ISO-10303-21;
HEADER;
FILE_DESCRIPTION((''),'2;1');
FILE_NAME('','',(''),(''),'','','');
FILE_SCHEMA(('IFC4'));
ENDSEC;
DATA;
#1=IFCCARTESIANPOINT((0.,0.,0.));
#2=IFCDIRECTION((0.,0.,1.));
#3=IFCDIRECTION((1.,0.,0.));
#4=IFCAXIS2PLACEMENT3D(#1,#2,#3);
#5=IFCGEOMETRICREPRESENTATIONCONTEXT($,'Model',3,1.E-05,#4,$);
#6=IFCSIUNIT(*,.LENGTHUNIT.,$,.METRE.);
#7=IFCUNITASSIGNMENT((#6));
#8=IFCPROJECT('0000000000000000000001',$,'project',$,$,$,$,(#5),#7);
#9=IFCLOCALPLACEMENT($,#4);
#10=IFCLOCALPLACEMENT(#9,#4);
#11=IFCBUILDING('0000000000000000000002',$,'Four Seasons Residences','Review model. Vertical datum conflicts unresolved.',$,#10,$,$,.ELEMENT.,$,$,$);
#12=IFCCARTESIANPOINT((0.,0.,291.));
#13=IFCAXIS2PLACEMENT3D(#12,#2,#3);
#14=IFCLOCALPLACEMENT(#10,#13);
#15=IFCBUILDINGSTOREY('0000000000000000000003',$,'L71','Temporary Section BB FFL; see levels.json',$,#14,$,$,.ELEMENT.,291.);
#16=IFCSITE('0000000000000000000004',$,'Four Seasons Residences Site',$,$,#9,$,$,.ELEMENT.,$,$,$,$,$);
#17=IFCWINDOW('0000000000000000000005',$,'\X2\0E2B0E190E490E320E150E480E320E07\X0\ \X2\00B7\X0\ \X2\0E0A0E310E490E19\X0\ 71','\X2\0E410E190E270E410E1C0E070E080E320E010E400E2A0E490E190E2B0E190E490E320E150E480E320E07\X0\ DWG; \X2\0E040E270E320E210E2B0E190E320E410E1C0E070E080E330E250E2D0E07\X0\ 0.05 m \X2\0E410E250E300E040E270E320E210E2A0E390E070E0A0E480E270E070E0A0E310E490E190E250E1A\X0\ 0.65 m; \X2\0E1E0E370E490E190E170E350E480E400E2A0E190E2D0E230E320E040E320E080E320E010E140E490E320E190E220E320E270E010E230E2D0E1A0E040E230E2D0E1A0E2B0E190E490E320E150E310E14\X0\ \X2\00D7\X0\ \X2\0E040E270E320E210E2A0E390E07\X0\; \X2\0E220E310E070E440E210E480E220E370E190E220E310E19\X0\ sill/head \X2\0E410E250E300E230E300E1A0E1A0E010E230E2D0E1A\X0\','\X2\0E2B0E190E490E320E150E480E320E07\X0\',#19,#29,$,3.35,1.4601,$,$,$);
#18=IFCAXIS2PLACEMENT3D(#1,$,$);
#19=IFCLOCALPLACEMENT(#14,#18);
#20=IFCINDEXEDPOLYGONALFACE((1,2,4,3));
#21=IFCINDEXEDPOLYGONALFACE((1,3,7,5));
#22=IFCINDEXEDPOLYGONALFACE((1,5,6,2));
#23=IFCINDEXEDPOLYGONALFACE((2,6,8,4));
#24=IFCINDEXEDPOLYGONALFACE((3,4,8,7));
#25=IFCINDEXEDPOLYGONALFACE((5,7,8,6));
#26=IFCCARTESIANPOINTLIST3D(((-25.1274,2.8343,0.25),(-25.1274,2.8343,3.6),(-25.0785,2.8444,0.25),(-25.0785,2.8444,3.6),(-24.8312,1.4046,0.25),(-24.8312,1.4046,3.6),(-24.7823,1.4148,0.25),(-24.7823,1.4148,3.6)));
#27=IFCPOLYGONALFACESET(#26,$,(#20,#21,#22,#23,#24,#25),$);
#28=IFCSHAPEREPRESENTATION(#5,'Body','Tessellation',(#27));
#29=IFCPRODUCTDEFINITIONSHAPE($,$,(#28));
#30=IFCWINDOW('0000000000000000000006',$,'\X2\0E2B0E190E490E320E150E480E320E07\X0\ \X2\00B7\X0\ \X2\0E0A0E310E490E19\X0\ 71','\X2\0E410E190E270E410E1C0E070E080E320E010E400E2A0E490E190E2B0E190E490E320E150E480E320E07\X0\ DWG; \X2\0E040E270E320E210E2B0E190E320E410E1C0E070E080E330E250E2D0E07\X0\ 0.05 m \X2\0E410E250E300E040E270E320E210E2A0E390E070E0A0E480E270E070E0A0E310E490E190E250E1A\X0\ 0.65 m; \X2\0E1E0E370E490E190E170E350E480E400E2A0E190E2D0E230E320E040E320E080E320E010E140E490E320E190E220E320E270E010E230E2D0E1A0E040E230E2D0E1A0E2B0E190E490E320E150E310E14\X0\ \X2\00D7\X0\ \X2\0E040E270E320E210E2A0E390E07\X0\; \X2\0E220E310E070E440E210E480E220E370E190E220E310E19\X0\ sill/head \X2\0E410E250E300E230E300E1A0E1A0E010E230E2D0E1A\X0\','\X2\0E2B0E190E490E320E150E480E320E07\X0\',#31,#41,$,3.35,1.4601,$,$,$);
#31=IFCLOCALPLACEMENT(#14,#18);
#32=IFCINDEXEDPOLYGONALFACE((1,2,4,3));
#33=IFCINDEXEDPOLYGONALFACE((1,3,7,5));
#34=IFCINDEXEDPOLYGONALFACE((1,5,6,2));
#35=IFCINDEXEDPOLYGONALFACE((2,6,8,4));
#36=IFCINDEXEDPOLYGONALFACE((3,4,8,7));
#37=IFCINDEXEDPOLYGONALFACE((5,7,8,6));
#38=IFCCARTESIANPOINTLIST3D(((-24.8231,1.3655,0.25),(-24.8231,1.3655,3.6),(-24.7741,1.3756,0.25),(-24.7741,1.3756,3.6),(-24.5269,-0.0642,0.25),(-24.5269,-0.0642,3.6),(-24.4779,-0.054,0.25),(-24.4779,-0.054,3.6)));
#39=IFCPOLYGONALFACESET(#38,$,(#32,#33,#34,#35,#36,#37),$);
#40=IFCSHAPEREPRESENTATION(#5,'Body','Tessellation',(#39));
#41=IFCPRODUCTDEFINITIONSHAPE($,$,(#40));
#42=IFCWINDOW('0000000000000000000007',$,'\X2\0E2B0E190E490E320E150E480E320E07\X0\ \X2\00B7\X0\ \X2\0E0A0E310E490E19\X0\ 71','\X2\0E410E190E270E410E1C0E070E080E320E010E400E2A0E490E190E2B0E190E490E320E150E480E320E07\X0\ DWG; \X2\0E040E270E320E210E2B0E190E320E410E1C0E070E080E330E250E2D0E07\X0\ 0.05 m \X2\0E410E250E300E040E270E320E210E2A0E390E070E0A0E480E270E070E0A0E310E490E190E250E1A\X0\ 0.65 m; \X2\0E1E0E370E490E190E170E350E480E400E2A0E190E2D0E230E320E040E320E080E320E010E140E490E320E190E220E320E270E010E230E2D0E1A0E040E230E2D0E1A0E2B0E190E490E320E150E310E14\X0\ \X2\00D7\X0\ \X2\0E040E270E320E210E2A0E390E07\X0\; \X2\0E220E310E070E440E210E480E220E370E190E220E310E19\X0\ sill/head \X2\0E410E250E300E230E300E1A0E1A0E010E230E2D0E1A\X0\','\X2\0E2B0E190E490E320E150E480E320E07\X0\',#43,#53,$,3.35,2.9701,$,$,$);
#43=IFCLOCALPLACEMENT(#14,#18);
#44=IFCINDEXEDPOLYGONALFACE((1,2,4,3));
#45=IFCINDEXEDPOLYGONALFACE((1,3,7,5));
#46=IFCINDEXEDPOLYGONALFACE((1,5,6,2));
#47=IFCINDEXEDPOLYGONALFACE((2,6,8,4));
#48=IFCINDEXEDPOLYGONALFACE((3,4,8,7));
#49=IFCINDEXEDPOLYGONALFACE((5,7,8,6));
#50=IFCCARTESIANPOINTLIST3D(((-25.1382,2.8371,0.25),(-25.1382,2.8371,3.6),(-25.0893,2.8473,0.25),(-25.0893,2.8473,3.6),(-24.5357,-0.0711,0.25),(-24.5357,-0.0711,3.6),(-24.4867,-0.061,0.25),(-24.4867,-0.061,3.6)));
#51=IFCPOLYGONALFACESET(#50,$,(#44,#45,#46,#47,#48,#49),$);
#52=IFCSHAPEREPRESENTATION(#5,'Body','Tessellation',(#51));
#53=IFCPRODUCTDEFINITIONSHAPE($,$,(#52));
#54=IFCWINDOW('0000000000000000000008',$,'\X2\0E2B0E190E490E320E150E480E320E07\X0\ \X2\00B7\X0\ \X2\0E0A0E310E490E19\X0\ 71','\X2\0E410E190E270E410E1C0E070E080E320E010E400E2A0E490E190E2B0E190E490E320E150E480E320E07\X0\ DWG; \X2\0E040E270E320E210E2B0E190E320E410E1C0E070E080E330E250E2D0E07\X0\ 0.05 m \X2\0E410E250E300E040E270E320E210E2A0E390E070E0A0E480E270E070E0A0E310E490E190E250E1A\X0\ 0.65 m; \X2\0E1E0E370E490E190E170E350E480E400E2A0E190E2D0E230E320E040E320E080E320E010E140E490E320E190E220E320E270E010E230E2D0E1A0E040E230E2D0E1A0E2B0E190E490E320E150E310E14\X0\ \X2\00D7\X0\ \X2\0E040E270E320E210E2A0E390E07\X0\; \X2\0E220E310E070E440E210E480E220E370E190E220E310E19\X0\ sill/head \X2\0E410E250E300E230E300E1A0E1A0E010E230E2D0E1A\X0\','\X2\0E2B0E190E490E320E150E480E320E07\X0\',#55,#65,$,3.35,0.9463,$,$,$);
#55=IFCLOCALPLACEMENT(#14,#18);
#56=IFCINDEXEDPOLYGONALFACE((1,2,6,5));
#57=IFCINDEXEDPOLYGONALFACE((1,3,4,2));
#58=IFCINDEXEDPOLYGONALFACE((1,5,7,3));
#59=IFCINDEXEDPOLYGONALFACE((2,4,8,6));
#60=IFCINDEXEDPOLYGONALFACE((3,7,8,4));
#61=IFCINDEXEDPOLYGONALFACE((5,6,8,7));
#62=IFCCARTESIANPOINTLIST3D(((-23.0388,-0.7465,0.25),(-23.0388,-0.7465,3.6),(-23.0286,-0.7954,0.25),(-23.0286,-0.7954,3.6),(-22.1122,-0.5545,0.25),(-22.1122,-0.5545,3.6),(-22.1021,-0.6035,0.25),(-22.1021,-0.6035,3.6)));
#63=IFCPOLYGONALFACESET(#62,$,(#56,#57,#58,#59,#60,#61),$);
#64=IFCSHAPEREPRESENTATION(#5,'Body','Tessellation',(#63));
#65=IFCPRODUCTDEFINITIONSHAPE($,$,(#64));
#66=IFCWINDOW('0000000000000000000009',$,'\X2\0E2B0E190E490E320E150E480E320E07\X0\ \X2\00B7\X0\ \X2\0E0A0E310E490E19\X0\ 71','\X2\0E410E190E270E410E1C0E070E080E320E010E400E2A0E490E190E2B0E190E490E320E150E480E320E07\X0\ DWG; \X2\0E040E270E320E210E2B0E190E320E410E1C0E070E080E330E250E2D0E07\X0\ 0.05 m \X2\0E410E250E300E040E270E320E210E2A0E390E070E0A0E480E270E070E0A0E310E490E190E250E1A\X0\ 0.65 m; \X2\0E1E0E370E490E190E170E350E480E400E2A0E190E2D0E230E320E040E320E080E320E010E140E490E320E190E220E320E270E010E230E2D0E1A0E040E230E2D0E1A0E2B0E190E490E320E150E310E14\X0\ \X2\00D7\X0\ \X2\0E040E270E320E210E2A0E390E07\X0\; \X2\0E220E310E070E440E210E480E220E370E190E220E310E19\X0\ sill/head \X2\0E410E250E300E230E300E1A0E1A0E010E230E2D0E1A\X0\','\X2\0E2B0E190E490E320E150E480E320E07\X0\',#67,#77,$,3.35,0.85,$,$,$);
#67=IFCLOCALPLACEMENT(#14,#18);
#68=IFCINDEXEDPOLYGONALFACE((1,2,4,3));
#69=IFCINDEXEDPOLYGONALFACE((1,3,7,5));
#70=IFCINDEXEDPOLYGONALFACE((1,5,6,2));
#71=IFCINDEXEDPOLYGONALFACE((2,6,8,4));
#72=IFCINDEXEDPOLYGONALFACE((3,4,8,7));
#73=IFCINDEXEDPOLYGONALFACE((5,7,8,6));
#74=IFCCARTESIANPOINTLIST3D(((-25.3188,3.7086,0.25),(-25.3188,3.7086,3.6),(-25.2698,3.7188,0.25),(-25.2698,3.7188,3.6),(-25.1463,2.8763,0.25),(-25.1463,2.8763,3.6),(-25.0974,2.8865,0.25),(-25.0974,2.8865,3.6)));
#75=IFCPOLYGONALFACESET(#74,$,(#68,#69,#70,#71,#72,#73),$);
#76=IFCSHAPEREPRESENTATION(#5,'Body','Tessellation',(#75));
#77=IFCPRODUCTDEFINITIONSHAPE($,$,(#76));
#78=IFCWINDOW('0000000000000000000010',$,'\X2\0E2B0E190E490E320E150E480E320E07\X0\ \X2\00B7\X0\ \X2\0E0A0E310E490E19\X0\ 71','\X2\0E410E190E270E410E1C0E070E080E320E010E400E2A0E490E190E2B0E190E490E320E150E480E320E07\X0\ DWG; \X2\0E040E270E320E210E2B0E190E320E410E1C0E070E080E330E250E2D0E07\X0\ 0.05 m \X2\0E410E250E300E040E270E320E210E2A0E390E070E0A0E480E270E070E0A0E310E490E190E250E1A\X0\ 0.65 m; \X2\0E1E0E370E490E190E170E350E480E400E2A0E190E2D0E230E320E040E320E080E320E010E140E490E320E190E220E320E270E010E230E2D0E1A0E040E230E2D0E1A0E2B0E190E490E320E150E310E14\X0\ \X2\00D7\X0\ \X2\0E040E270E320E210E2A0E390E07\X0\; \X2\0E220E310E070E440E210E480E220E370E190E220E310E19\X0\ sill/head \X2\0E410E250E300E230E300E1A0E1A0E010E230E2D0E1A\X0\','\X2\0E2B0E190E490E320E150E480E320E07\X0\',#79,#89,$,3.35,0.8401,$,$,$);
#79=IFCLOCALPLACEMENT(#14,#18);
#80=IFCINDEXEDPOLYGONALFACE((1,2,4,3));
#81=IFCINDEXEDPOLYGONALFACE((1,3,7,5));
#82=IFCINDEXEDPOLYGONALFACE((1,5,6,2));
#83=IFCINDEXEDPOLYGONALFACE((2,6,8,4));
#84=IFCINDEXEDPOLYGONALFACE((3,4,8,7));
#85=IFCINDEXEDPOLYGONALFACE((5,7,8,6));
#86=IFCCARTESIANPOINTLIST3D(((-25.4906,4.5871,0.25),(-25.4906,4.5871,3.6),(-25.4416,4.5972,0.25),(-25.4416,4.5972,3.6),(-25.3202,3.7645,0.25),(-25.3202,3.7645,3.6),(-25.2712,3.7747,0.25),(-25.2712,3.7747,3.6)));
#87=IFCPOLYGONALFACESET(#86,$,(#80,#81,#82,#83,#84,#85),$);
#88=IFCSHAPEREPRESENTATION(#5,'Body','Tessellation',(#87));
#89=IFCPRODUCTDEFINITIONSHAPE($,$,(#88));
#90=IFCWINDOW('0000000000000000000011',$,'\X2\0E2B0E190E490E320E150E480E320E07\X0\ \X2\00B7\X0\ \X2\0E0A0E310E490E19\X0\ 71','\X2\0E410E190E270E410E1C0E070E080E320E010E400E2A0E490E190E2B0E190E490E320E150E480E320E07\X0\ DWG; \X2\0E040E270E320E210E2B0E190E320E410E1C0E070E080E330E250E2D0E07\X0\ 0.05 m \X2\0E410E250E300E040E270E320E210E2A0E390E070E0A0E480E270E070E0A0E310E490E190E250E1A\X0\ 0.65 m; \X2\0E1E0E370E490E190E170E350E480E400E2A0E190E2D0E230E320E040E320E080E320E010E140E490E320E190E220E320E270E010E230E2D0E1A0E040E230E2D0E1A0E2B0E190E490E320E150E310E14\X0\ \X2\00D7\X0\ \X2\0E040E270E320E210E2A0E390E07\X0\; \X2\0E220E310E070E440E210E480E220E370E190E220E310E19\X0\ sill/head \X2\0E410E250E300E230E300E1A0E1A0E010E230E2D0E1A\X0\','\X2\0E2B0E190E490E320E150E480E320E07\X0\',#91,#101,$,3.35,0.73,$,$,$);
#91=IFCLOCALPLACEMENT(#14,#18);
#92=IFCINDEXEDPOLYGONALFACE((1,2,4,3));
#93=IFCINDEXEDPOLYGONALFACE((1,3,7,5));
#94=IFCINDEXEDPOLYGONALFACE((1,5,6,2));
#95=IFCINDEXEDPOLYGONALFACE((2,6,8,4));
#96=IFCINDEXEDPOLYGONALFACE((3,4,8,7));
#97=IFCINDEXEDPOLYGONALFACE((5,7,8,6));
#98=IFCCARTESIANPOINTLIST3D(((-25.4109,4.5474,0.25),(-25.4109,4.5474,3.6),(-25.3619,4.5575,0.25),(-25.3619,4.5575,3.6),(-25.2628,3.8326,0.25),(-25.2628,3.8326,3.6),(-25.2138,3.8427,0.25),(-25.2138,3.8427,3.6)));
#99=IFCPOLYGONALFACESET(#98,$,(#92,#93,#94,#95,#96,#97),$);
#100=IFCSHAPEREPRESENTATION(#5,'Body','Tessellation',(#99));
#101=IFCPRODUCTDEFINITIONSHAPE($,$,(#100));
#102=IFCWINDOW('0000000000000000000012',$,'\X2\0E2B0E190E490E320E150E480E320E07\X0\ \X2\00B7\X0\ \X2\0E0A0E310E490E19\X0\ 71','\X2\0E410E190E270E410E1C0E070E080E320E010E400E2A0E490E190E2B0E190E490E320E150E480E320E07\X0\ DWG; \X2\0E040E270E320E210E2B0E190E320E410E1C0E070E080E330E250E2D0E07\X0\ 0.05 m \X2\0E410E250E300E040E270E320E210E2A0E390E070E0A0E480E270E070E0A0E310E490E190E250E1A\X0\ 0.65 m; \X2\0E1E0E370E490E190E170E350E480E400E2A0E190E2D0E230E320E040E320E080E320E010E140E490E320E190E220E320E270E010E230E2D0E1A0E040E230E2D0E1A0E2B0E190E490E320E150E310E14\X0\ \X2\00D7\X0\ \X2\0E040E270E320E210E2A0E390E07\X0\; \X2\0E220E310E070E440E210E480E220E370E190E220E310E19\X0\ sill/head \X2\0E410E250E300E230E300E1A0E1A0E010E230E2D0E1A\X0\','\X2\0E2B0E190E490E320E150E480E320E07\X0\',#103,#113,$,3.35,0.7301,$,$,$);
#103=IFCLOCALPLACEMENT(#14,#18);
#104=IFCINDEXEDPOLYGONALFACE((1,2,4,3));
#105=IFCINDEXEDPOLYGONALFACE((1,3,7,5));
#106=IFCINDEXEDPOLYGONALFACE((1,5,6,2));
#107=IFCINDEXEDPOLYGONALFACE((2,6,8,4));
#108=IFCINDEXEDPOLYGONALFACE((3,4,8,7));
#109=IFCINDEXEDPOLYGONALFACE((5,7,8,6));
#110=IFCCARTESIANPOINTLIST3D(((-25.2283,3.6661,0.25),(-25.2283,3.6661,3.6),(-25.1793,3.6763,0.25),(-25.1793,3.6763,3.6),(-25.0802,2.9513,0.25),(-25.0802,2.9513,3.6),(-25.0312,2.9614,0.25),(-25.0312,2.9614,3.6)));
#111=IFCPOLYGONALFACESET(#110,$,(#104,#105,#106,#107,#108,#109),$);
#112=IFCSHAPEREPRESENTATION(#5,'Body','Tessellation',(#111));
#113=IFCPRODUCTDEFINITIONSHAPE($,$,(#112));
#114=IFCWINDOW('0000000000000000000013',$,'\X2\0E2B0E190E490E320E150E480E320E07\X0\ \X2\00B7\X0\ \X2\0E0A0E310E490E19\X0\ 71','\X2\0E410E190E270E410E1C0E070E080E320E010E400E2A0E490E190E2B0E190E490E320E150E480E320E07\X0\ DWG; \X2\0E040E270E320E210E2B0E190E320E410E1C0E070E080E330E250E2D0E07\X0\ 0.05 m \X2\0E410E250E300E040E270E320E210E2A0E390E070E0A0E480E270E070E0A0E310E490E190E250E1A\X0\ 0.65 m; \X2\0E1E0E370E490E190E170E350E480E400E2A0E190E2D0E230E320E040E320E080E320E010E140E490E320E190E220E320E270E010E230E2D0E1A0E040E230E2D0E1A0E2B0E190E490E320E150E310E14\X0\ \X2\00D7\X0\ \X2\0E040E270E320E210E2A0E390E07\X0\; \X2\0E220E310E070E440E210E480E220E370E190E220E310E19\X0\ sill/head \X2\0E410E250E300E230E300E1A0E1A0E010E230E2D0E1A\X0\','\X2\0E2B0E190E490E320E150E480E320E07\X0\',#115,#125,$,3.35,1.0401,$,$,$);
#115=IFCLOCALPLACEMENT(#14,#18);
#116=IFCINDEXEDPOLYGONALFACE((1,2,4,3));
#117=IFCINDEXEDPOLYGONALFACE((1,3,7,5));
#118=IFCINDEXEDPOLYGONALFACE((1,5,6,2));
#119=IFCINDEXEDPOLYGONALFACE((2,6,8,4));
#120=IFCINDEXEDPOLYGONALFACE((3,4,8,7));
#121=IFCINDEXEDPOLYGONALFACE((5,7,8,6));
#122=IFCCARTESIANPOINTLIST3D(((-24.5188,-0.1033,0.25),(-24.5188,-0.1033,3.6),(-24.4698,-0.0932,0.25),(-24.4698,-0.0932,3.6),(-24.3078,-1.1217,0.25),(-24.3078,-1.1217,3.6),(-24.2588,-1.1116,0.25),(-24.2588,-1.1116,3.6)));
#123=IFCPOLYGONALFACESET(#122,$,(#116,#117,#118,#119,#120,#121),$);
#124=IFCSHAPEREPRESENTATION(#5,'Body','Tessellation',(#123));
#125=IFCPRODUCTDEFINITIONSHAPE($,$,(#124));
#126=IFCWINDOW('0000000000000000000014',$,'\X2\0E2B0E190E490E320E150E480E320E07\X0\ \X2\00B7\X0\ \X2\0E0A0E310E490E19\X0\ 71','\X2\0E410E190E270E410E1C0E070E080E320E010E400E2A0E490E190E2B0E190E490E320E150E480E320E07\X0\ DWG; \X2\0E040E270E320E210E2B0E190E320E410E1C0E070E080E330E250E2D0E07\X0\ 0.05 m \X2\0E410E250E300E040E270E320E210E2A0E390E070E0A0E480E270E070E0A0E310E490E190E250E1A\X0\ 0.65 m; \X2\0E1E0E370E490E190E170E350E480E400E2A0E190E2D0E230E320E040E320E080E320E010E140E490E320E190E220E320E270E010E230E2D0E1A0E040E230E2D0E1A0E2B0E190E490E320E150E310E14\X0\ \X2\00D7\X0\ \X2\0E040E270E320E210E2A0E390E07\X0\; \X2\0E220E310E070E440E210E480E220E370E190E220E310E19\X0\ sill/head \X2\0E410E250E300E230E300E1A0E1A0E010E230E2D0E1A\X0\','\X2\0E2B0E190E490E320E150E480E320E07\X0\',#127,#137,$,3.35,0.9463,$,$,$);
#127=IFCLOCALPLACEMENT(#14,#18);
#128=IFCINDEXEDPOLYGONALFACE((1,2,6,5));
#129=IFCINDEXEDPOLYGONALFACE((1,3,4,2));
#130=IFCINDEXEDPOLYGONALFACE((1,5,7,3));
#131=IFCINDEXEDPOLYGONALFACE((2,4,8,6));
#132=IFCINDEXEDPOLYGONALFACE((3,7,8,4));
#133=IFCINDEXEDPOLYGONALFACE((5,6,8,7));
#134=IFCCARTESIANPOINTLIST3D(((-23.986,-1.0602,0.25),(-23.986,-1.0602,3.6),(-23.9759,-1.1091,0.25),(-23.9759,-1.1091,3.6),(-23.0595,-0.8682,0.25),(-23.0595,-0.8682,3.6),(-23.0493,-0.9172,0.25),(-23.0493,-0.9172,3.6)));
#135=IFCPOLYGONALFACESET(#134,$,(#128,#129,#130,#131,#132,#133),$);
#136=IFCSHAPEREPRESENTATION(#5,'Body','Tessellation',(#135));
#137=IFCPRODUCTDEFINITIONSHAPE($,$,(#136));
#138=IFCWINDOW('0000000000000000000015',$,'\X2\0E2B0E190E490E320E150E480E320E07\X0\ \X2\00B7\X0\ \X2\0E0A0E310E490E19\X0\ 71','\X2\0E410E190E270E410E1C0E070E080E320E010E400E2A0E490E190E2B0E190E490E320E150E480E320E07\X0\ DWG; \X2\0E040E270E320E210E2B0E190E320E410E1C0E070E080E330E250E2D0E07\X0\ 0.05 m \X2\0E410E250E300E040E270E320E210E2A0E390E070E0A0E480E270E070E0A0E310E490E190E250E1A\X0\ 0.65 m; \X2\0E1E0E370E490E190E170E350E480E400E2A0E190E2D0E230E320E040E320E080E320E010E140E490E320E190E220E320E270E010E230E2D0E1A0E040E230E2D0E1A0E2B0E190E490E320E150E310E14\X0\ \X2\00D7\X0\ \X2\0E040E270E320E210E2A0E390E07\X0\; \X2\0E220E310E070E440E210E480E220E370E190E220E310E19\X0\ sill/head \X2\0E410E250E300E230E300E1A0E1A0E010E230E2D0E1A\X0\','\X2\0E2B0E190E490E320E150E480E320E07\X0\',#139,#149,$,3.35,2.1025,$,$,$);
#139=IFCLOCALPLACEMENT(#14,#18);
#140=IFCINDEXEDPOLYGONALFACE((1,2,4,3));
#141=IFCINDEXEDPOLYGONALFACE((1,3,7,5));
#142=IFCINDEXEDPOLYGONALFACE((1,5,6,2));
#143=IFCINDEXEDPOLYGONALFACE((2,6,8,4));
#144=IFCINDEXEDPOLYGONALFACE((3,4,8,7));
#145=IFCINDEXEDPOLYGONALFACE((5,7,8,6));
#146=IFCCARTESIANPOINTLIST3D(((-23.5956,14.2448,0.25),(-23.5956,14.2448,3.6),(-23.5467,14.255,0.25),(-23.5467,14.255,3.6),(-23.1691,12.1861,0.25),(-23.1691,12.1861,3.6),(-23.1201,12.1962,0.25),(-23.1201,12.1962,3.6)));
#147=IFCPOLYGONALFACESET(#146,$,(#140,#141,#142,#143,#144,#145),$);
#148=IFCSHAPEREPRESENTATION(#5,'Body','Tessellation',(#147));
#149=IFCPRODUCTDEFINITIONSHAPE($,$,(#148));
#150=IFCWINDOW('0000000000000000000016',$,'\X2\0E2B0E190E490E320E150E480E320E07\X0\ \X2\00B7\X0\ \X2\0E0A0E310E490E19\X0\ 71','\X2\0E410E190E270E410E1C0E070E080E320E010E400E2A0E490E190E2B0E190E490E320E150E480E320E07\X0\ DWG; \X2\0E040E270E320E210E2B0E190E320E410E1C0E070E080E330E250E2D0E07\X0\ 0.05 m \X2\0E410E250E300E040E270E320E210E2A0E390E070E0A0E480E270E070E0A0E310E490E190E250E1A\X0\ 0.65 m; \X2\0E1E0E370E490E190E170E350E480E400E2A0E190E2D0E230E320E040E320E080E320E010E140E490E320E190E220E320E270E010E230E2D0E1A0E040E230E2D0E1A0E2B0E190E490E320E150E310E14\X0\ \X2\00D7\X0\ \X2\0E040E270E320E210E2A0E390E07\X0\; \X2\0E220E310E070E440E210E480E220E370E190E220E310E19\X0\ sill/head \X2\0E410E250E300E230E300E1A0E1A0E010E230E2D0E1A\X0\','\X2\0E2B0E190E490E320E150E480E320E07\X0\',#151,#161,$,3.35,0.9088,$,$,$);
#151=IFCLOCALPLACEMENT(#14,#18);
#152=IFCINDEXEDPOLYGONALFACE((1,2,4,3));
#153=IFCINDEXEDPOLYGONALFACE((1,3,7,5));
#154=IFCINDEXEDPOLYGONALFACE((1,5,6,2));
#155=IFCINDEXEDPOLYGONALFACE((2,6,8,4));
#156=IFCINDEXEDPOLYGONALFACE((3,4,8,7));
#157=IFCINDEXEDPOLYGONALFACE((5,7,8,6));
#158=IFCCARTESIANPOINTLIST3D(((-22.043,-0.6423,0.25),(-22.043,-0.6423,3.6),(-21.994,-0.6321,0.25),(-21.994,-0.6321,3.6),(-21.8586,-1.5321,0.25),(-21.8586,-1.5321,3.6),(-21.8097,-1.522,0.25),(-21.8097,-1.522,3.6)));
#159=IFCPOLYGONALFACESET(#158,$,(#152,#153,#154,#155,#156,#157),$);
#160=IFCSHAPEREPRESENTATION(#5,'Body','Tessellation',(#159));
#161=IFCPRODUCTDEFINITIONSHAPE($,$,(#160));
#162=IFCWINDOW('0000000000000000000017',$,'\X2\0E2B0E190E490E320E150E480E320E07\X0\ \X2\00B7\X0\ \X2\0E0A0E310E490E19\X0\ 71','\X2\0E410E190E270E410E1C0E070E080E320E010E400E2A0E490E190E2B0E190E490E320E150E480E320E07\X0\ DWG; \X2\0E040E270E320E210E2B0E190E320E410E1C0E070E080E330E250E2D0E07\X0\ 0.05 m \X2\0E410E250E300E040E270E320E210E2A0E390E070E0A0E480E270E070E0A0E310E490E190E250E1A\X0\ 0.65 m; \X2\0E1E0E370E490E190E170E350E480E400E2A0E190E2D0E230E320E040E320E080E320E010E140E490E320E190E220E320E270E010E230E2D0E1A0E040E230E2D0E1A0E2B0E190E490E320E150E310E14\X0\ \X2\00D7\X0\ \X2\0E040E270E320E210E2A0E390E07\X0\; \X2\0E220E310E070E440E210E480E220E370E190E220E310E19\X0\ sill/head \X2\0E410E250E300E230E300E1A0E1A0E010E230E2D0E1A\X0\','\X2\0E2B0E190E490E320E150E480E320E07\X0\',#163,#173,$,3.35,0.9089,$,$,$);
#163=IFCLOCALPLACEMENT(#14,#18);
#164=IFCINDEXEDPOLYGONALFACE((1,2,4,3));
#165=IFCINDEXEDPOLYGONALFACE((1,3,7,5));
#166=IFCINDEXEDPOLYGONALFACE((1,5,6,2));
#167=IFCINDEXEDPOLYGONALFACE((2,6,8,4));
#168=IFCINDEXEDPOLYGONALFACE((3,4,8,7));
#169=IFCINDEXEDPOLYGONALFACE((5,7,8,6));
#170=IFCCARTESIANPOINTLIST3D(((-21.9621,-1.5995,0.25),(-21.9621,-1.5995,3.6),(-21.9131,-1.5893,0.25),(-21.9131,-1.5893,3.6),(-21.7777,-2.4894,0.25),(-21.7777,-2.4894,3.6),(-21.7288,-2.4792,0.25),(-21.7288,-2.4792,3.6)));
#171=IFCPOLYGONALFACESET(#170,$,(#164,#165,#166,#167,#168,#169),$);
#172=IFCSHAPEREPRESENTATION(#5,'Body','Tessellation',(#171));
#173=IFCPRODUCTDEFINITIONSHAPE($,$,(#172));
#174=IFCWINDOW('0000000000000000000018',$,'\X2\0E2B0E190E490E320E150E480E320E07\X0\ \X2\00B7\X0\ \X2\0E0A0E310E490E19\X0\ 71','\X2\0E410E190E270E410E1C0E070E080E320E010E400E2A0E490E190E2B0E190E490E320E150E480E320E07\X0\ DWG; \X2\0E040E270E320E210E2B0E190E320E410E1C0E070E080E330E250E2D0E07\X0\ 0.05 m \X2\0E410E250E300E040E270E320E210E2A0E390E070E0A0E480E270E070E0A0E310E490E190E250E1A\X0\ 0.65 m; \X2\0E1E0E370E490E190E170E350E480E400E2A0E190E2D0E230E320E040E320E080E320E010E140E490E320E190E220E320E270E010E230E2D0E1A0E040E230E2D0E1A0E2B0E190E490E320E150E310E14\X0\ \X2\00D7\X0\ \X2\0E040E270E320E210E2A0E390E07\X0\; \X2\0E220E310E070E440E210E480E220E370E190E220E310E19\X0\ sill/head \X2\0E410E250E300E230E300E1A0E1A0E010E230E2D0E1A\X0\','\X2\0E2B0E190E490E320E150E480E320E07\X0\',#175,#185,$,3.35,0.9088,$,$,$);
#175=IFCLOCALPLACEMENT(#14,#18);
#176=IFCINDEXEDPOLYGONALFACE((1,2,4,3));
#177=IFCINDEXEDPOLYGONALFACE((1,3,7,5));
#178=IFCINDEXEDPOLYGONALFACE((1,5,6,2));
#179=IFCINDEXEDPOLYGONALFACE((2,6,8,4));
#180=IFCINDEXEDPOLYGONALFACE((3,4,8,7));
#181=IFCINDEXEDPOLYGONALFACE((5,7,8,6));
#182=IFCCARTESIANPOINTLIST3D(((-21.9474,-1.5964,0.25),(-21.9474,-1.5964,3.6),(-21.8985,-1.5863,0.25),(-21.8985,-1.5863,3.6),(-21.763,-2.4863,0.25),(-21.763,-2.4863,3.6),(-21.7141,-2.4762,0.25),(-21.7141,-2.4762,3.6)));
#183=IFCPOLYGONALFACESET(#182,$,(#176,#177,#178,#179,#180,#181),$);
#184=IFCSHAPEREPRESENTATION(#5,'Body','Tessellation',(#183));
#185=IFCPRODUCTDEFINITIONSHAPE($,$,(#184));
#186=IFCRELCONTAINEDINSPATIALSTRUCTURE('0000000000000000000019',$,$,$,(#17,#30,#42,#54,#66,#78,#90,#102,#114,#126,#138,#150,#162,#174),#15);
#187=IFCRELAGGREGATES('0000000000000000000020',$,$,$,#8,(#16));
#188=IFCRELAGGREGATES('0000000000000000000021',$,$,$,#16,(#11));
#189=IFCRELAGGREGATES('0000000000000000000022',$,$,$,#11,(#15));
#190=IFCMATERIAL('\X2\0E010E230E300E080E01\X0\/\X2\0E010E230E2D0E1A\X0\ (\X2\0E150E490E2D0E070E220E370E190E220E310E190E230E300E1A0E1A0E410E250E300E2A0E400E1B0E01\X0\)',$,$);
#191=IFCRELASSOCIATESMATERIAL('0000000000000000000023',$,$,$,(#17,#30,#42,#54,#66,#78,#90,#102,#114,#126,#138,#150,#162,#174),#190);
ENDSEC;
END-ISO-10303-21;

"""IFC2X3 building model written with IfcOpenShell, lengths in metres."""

from ifc_helpers import new_model, si_unit, frame, origin_with_axes, place, context, project, spatial, polyline, outline, extrude, material, element, save


model = new_model("IFC2X3")

# Units and contexts
model_context = context("Model", 3, precision=1e-05, world=origin_with_axes())
ifc_project = project(units=[si_unit("LENGTHUNIT", "METRE")], contexts=[model_context])

# Site, building, storey
site_placement = place(None, origin_with_axes())
site = spatial("IfcSite", under=ifc_project, at=site_placement, Name="Four Seasons Residences Site", CompositionType="ELEMENT")
building_placement = place(site_placement, origin_with_axes())
building = spatial("IfcBuilding", under=site, at=building_placement, Name="Four Seasons Residences", Description="Review model. Vertical datum conflicts unresolved.", CompositionType="ELEMENT")
storey_placement = place(building_placement, frame((0.0, 0.0, 291.0), z_axis=(0.0, 0.0, 1.0), x_axis=(1.0, 0.0, 0.0)))
storey = spatial("IfcBuildingStorey", under=building, at=storey_placement, Name="L71", Description="Temporary Section BB FFL; see levels.json", CompositionType="ELEMENT", Elevation=291.0)

# Windows
ifc_material_1 = material(Name="กระจก/กรอบ (ต้องยืนยันระบบและสเปก)")
window_1_placement = place(storey_placement, origin_with_axes())
element("IfcWindow", 1, at=window_1_placement, inside=storey, material=ifc_material_1, Name="หน้าต่าง · ชั้น 71", Description="แนวแผงจากเส้นหน้าต่าง DWG; ความหนาแผงจำลอง 0.05 m และความสูงช่วงชั้นลบ 0.65 m; พื้นที่เสนอราคาจากด้านยาวกรอบครอบหน้าตัด × ความสูง; ยังไม่ยืนยัน sill/head และระบบกรอบ", ObjectType="หน้าต่าง", OverallHeight=3.35, OverallWidth=1.4601, context=model_context, shape_type="SweptSolid", body=[
    extrude(outline(polyline([(-24.7823, 1.4148), (-24.8312, 1.4046), (-25.1274, 2.8343), (-25.0785, 2.8444), (-24.7823, 1.4148)])), frame((0.0, 0.0, 0.25), z_axis=(0.0, 0.0, 1.0), x_axis=(1.0, 0.0, 0.0)), (0.0, 0.0, 1.0), 3.35),
])
window_2_placement = place(storey_placement, origin_with_axes())
element("IfcWindow", 2, at=window_2_placement, inside=storey, material=ifc_material_1, Name="หน้าต่าง · ชั้น 71", Description="แนวแผงจากเส้นหน้าต่าง DWG; ความหนาแผงจำลอง 0.05 m และความสูงช่วงชั้นลบ 0.65 m; พื้นที่เสนอราคาจากด้านยาวกรอบครอบหน้าตัด × ความสูง; ยังไม่ยืนยัน sill/head และระบบกรอบ", ObjectType="หน้าต่าง", OverallHeight=3.35, OverallWidth=1.4601, context=model_context, shape_type="SweptSolid", body=[
    extrude(outline(polyline([(-24.4779, -0.054), (-24.5269, -0.0642), (-24.8231, 1.3655), (-24.7741, 1.3756), (-24.4779, -0.054)])), frame((0.0, 0.0, 0.25), z_axis=(0.0, 0.0, 1.0), x_axis=(1.0, 0.0, 0.0)), (0.0, 0.0, 1.0), 3.35),
])
window_3_placement = place(storey_placement, origin_with_axes())
element("IfcWindow", 3, at=window_3_placement, inside=storey, material=ifc_material_1, Name="หน้าต่าง · ชั้น 71", Description="แนวแผงจากเส้นหน้าต่าง DWG; ความหนาแผงจำลอง 0.05 m และความสูงช่วงชั้นลบ 0.65 m; พื้นที่เสนอราคาจากด้านยาวกรอบครอบหน้าตัด × ความสูง; ยังไม่ยืนยัน sill/head และระบบกรอบ", ObjectType="หน้าต่าง", OverallHeight=3.35, OverallWidth=2.9701, context=model_context, shape_type="SweptSolid", body=[
    extrude(outline(polyline([(-24.4867, -0.061), (-24.5357, -0.0711), (-25.1382, 2.8371), (-25.0893, 2.8473), (-24.4867, -0.061)])), frame((0.0, 0.0, 0.25), z_axis=(0.0, 0.0, 1.0), x_axis=(1.0, 0.0, 0.0)), (0.0, 0.0, 1.0), 3.35),
])
window_4_placement = place(storey_placement, origin_with_axes())
element("IfcWindow", 4, at=window_4_placement, inside=storey, material=ifc_material_1, Name="หน้าต่าง · ชั้น 71", Description="แนวแผงจากเส้นหน้าต่าง DWG; ความหนาแผงจำลอง 0.05 m และความสูงช่วงชั้นลบ 0.65 m; พื้นที่เสนอราคาจากด้านยาวกรอบครอบหน้าตัด × ความสูง; ยังไม่ยืนยัน sill/head และระบบกรอบ", ObjectType="หน้าต่าง", OverallHeight=3.35, OverallWidth=0.9463, context=model_context, shape_type="SweptSolid", body=[
    extrude(outline(polyline([(-23.0286, -0.7954), (-23.0388, -0.7465), (-22.1122, -0.5545), (-22.1021, -0.6035), (-23.0286, -0.7954)])), frame((0.0, 0.0, 0.25), z_axis=(0.0, 0.0, 1.0), x_axis=(1.0, 0.0, 0.0)), (0.0, 0.0, 1.0), 3.35),
])
window_5_placement = place(storey_placement, origin_with_axes())
element("IfcWindow", 5, at=window_5_placement, inside=storey, material=ifc_material_1, Name="หน้าต่าง · ชั้น 71", Description="แนวแผงจากเส้นหน้าต่าง DWG; ความหนาแผงจำลอง 0.05 m และความสูงช่วงชั้นลบ 0.65 m; พื้นที่เสนอราคาจากด้านยาวกรอบครอบหน้าตัด × ความสูง; ยังไม่ยืนยัน sill/head และระบบกรอบ", ObjectType="หน้าต่าง", OverallHeight=3.35, OverallWidth=0.85, context=model_context, shape_type="SweptSolid", body=[
    extrude(outline(polyline([(-25.3188, 3.7086), (-25.2698, 3.7188), (-25.0974, 2.8865), (-25.1463, 2.8763), (-25.3188, 3.7086)])), frame((0.0, 0.0, 0.25), z_axis=(0.0, 0.0, 1.0), x_axis=(1.0, 0.0, 0.0)), (0.0, 0.0, 1.0), 3.35),
])
window_6_placement = place(storey_placement, origin_with_axes())
element("IfcWindow", 6, at=window_6_placement, inside=storey, material=ifc_material_1, Name="หน้าต่าง · ชั้น 71", Description="แนวแผงจากเส้นหน้าต่าง DWG; ความหนาแผงจำลอง 0.05 m และความสูงช่วงชั้นลบ 0.65 m; พื้นที่เสนอราคาจากด้านยาวกรอบครอบหน้าตัด × ความสูง; ยังไม่ยืนยัน sill/head และระบบกรอบ", ObjectType="หน้าต่าง", OverallHeight=3.35, OverallWidth=0.8401, context=model_context, shape_type="SweptSolid", body=[
    extrude(outline(polyline([(-25.2712, 3.7747), (-25.3202, 3.7645), (-25.4906, 4.5871), (-25.4416, 4.5972), (-25.2712, 3.7747)])), frame((0.0, 0.0, 0.25), z_axis=(0.0, 0.0, 1.0), x_axis=(1.0, 0.0, 0.0)), (0.0, 0.0, 1.0), 3.35),
])
window_7_placement = place(storey_placement, origin_with_axes())
element("IfcWindow", 7, at=window_7_placement, inside=storey, material=ifc_material_1, Name="หน้าต่าง · ชั้น 71", Description="แนวแผงจากเส้นหน้าต่าง DWG; ความหนาแผงจำลอง 0.05 m และความสูงช่วงชั้นลบ 0.65 m; พื้นที่เสนอราคาจากด้านยาวกรอบครอบหน้าตัด × ความสูง; ยังไม่ยืนยัน sill/head และระบบกรอบ", ObjectType="หน้าต่าง", OverallHeight=3.35, OverallWidth=0.73, context=model_context, shape_type="SweptSolid", body=[
    extrude(outline(polyline([(-25.2138, 3.8427), (-25.2628, 3.8326), (-25.4109, 4.5474), (-25.3619, 4.5575), (-25.2138, 3.8427)])), frame((0.0, 0.0, 0.25), z_axis=(0.0, 0.0, 1.0), x_axis=(1.0, 0.0, 0.0)), (0.0, 0.0, 1.0), 3.35),
])
window_8_placement = place(storey_placement, origin_with_axes())
element("IfcWindow", 8, at=window_8_placement, inside=storey, material=ifc_material_1, Name="หน้าต่าง · ชั้น 71", Description="แนวแผงจากเส้นหน้าต่าง DWG; ความหนาแผงจำลอง 0.05 m และความสูงช่วงชั้นลบ 0.65 m; พื้นที่เสนอราคาจากด้านยาวกรอบครอบหน้าตัด × ความสูง; ยังไม่ยืนยัน sill/head และระบบกรอบ", ObjectType="หน้าต่าง", OverallHeight=3.35, OverallWidth=0.7301, context=model_context, shape_type="SweptSolid", body=[
    extrude(outline(polyline([(-25.0312, 2.9614), (-25.0802, 2.9513), (-25.2283, 3.6661), (-25.1793, 3.6763), (-25.0312, 2.9614)])), frame((0.0, 0.0, 0.25), z_axis=(0.0, 0.0, 1.0), x_axis=(1.0, 0.0, 0.0)), (0.0, 0.0, 1.0), 3.35),
])
window_9_placement = place(storey_placement, origin_with_axes())
element("IfcWindow", 9, at=window_9_placement, inside=storey, material=ifc_material_1, Name="หน้าต่าง · ชั้น 71", Description="แนวแผงจากเส้นหน้าต่าง DWG; ความหนาแผงจำลอง 0.05 m และความสูงช่วงชั้นลบ 0.65 m; พื้นที่เสนอราคาจากด้านยาวกรอบครอบหน้าตัด × ความสูง; ยังไม่ยืนยัน sill/head และระบบกรอบ", ObjectType="หน้าต่าง", OverallHeight=3.35, OverallWidth=1.0401, context=model_context, shape_type="SweptSolid", body=[
    extrude(outline(polyline([(-24.2588, -1.1116), (-24.3078, -1.1217), (-24.5188, -0.1033), (-24.4698, -0.0932), (-24.2588, -1.1116)])), frame((0.0, 0.0, 0.25), z_axis=(0.0, 0.0, 1.0), x_axis=(1.0, 0.0, 0.0)), (0.0, 0.0, 1.0), 3.35),
])
window_10_placement = place(storey_placement, origin_with_axes())
element("IfcWindow", 10, at=window_10_placement, inside=storey, material=ifc_material_1, Name="หน้าต่าง · ชั้น 71", Description="แนวแผงจากเส้นหน้าต่าง DWG; ความหนาแผงจำลอง 0.05 m และความสูงช่วงชั้นลบ 0.65 m; พื้นที่เสนอราคาจากด้านยาวกรอบครอบหน้าตัด × ความสูง; ยังไม่ยืนยัน sill/head และระบบกรอบ", ObjectType="หน้าต่าง", OverallHeight=3.35, OverallWidth=0.9463, context=model_context, shape_type="SweptSolid", body=[
    extrude(outline(polyline([(-23.9759, -1.1091), (-23.986, -1.0602), (-23.0595, -0.8682), (-23.0493, -0.9172), (-23.9759, -1.1091)])), frame((0.0, 0.0, 0.25), z_axis=(0.0, 0.0, 1.0), x_axis=(1.0, 0.0, 0.0)), (0.0, 0.0, 1.0), 3.35),
])
window_11_placement = place(storey_placement, origin_with_axes())
element("IfcWindow", 11, at=window_11_placement, inside=storey, material=ifc_material_1, Name="หน้าต่าง · ชั้น 71", Description="แนวแผงจากเส้นหน้าต่าง DWG; ความหนาแผงจำลอง 0.05 m และความสูงช่วงชั้นลบ 0.65 m; พื้นที่เสนอราคาจากด้านยาวกรอบครอบหน้าตัด × ความสูง; ยังไม่ยืนยัน sill/head และระบบกรอบ", ObjectType="หน้าต่าง", OverallHeight=3.35, OverallWidth=2.1025, context=model_context, shape_type="SweptSolid", body=[
    extrude(outline(polyline([(-23.5956, 14.2448), (-23.5467, 14.255), (-23.1201, 12.1962), (-23.1691, 12.1861), (-23.5956, 14.2448)])), frame((0.0, 0.0, 0.25), z_axis=(0.0, 0.0, 1.0), x_axis=(1.0, 0.0, 0.0)), (0.0, 0.0, 1.0), 3.35),
])
window_12_placement = place(storey_placement, origin_with_axes())
element("IfcWindow", 12, at=window_12_placement, inside=storey, material=ifc_material_1, Name="หน้าต่าง · ชั้น 71", Description="แนวแผงจากเส้นหน้าต่าง DWG; ความหนาแผงจำลอง 0.05 m และความสูงช่วงชั้นลบ 0.65 m; พื้นที่เสนอราคาจากด้านยาวกรอบครอบหน้าตัด × ความสูง; ยังไม่ยืนยัน sill/head และระบบกรอบ", ObjectType="หน้าต่าง", OverallHeight=3.35, OverallWidth=0.9088, context=model_context, shape_type="SweptSolid", body=[
    extrude(outline(polyline([(-21.8097, -1.522), (-21.8586, -1.5321), (-22.043, -0.6423), (-21.994, -0.6321), (-21.8097, -1.522)])), frame((0.0, 0.0, 0.25), z_axis=(0.0, 0.0, 1.0), x_axis=(1.0, 0.0, 0.0)), (0.0, 0.0, 1.0), 3.35),
])
window_13_placement = place(storey_placement, origin_with_axes())
element("IfcWindow", 13, at=window_13_placement, inside=storey, material=ifc_material_1, Name="หน้าต่าง · ชั้น 71", Description="แนวแผงจากเส้นหน้าต่าง DWG; ความหนาแผงจำลอง 0.05 m และความสูงช่วงชั้นลบ 0.65 m; พื้นที่เสนอราคาจากด้านยาวกรอบครอบหน้าตัด × ความสูง; ยังไม่ยืนยัน sill/head และระบบกรอบ", ObjectType="หน้าต่าง", OverallHeight=3.35, OverallWidth=0.9089, context=model_context, shape_type="SweptSolid", body=[
    extrude(outline(polyline([(-21.7288, -2.4792), (-21.7777, -2.4894), (-21.9621, -1.5995), (-21.9131, -1.5893), (-21.7288, -2.4792)])), frame((0.0, 0.0, 0.25), z_axis=(0.0, 0.0, 1.0), x_axis=(1.0, 0.0, 0.0)), (0.0, 0.0, 1.0), 3.35),
])
window_14_placement = place(storey_placement, origin_with_axes())
element("IfcWindow", 14, at=window_14_placement, inside=storey, material=ifc_material_1, Name="หน้าต่าง · ชั้น 71", Description="แนวแผงจากเส้นหน้าต่าง DWG; ความหนาแผงจำลอง 0.05 m และความสูงช่วงชั้นลบ 0.65 m; พื้นที่เสนอราคาจากด้านยาวกรอบครอบหน้าตัด × ความสูง; ยังไม่ยืนยัน sill/head และระบบกรอบ", ObjectType="หน้าต่าง", OverallHeight=3.35, OverallWidth=0.9088, context=model_context, shape_type="SweptSolid", body=[
    extrude(outline(polyline([(-21.7141, -2.4762), (-21.763, -2.4863), (-21.9474, -1.5964), (-21.8985, -1.5863), (-21.7141, -2.4762)])), frame((0.0, 0.0, 0.25), z_axis=(0.0, 0.0, 1.0), x_axis=(1.0, 0.0, 0.0)), (0.0, 0.0, 1.0), 3.35),
])

save(model, "model.ifc")
